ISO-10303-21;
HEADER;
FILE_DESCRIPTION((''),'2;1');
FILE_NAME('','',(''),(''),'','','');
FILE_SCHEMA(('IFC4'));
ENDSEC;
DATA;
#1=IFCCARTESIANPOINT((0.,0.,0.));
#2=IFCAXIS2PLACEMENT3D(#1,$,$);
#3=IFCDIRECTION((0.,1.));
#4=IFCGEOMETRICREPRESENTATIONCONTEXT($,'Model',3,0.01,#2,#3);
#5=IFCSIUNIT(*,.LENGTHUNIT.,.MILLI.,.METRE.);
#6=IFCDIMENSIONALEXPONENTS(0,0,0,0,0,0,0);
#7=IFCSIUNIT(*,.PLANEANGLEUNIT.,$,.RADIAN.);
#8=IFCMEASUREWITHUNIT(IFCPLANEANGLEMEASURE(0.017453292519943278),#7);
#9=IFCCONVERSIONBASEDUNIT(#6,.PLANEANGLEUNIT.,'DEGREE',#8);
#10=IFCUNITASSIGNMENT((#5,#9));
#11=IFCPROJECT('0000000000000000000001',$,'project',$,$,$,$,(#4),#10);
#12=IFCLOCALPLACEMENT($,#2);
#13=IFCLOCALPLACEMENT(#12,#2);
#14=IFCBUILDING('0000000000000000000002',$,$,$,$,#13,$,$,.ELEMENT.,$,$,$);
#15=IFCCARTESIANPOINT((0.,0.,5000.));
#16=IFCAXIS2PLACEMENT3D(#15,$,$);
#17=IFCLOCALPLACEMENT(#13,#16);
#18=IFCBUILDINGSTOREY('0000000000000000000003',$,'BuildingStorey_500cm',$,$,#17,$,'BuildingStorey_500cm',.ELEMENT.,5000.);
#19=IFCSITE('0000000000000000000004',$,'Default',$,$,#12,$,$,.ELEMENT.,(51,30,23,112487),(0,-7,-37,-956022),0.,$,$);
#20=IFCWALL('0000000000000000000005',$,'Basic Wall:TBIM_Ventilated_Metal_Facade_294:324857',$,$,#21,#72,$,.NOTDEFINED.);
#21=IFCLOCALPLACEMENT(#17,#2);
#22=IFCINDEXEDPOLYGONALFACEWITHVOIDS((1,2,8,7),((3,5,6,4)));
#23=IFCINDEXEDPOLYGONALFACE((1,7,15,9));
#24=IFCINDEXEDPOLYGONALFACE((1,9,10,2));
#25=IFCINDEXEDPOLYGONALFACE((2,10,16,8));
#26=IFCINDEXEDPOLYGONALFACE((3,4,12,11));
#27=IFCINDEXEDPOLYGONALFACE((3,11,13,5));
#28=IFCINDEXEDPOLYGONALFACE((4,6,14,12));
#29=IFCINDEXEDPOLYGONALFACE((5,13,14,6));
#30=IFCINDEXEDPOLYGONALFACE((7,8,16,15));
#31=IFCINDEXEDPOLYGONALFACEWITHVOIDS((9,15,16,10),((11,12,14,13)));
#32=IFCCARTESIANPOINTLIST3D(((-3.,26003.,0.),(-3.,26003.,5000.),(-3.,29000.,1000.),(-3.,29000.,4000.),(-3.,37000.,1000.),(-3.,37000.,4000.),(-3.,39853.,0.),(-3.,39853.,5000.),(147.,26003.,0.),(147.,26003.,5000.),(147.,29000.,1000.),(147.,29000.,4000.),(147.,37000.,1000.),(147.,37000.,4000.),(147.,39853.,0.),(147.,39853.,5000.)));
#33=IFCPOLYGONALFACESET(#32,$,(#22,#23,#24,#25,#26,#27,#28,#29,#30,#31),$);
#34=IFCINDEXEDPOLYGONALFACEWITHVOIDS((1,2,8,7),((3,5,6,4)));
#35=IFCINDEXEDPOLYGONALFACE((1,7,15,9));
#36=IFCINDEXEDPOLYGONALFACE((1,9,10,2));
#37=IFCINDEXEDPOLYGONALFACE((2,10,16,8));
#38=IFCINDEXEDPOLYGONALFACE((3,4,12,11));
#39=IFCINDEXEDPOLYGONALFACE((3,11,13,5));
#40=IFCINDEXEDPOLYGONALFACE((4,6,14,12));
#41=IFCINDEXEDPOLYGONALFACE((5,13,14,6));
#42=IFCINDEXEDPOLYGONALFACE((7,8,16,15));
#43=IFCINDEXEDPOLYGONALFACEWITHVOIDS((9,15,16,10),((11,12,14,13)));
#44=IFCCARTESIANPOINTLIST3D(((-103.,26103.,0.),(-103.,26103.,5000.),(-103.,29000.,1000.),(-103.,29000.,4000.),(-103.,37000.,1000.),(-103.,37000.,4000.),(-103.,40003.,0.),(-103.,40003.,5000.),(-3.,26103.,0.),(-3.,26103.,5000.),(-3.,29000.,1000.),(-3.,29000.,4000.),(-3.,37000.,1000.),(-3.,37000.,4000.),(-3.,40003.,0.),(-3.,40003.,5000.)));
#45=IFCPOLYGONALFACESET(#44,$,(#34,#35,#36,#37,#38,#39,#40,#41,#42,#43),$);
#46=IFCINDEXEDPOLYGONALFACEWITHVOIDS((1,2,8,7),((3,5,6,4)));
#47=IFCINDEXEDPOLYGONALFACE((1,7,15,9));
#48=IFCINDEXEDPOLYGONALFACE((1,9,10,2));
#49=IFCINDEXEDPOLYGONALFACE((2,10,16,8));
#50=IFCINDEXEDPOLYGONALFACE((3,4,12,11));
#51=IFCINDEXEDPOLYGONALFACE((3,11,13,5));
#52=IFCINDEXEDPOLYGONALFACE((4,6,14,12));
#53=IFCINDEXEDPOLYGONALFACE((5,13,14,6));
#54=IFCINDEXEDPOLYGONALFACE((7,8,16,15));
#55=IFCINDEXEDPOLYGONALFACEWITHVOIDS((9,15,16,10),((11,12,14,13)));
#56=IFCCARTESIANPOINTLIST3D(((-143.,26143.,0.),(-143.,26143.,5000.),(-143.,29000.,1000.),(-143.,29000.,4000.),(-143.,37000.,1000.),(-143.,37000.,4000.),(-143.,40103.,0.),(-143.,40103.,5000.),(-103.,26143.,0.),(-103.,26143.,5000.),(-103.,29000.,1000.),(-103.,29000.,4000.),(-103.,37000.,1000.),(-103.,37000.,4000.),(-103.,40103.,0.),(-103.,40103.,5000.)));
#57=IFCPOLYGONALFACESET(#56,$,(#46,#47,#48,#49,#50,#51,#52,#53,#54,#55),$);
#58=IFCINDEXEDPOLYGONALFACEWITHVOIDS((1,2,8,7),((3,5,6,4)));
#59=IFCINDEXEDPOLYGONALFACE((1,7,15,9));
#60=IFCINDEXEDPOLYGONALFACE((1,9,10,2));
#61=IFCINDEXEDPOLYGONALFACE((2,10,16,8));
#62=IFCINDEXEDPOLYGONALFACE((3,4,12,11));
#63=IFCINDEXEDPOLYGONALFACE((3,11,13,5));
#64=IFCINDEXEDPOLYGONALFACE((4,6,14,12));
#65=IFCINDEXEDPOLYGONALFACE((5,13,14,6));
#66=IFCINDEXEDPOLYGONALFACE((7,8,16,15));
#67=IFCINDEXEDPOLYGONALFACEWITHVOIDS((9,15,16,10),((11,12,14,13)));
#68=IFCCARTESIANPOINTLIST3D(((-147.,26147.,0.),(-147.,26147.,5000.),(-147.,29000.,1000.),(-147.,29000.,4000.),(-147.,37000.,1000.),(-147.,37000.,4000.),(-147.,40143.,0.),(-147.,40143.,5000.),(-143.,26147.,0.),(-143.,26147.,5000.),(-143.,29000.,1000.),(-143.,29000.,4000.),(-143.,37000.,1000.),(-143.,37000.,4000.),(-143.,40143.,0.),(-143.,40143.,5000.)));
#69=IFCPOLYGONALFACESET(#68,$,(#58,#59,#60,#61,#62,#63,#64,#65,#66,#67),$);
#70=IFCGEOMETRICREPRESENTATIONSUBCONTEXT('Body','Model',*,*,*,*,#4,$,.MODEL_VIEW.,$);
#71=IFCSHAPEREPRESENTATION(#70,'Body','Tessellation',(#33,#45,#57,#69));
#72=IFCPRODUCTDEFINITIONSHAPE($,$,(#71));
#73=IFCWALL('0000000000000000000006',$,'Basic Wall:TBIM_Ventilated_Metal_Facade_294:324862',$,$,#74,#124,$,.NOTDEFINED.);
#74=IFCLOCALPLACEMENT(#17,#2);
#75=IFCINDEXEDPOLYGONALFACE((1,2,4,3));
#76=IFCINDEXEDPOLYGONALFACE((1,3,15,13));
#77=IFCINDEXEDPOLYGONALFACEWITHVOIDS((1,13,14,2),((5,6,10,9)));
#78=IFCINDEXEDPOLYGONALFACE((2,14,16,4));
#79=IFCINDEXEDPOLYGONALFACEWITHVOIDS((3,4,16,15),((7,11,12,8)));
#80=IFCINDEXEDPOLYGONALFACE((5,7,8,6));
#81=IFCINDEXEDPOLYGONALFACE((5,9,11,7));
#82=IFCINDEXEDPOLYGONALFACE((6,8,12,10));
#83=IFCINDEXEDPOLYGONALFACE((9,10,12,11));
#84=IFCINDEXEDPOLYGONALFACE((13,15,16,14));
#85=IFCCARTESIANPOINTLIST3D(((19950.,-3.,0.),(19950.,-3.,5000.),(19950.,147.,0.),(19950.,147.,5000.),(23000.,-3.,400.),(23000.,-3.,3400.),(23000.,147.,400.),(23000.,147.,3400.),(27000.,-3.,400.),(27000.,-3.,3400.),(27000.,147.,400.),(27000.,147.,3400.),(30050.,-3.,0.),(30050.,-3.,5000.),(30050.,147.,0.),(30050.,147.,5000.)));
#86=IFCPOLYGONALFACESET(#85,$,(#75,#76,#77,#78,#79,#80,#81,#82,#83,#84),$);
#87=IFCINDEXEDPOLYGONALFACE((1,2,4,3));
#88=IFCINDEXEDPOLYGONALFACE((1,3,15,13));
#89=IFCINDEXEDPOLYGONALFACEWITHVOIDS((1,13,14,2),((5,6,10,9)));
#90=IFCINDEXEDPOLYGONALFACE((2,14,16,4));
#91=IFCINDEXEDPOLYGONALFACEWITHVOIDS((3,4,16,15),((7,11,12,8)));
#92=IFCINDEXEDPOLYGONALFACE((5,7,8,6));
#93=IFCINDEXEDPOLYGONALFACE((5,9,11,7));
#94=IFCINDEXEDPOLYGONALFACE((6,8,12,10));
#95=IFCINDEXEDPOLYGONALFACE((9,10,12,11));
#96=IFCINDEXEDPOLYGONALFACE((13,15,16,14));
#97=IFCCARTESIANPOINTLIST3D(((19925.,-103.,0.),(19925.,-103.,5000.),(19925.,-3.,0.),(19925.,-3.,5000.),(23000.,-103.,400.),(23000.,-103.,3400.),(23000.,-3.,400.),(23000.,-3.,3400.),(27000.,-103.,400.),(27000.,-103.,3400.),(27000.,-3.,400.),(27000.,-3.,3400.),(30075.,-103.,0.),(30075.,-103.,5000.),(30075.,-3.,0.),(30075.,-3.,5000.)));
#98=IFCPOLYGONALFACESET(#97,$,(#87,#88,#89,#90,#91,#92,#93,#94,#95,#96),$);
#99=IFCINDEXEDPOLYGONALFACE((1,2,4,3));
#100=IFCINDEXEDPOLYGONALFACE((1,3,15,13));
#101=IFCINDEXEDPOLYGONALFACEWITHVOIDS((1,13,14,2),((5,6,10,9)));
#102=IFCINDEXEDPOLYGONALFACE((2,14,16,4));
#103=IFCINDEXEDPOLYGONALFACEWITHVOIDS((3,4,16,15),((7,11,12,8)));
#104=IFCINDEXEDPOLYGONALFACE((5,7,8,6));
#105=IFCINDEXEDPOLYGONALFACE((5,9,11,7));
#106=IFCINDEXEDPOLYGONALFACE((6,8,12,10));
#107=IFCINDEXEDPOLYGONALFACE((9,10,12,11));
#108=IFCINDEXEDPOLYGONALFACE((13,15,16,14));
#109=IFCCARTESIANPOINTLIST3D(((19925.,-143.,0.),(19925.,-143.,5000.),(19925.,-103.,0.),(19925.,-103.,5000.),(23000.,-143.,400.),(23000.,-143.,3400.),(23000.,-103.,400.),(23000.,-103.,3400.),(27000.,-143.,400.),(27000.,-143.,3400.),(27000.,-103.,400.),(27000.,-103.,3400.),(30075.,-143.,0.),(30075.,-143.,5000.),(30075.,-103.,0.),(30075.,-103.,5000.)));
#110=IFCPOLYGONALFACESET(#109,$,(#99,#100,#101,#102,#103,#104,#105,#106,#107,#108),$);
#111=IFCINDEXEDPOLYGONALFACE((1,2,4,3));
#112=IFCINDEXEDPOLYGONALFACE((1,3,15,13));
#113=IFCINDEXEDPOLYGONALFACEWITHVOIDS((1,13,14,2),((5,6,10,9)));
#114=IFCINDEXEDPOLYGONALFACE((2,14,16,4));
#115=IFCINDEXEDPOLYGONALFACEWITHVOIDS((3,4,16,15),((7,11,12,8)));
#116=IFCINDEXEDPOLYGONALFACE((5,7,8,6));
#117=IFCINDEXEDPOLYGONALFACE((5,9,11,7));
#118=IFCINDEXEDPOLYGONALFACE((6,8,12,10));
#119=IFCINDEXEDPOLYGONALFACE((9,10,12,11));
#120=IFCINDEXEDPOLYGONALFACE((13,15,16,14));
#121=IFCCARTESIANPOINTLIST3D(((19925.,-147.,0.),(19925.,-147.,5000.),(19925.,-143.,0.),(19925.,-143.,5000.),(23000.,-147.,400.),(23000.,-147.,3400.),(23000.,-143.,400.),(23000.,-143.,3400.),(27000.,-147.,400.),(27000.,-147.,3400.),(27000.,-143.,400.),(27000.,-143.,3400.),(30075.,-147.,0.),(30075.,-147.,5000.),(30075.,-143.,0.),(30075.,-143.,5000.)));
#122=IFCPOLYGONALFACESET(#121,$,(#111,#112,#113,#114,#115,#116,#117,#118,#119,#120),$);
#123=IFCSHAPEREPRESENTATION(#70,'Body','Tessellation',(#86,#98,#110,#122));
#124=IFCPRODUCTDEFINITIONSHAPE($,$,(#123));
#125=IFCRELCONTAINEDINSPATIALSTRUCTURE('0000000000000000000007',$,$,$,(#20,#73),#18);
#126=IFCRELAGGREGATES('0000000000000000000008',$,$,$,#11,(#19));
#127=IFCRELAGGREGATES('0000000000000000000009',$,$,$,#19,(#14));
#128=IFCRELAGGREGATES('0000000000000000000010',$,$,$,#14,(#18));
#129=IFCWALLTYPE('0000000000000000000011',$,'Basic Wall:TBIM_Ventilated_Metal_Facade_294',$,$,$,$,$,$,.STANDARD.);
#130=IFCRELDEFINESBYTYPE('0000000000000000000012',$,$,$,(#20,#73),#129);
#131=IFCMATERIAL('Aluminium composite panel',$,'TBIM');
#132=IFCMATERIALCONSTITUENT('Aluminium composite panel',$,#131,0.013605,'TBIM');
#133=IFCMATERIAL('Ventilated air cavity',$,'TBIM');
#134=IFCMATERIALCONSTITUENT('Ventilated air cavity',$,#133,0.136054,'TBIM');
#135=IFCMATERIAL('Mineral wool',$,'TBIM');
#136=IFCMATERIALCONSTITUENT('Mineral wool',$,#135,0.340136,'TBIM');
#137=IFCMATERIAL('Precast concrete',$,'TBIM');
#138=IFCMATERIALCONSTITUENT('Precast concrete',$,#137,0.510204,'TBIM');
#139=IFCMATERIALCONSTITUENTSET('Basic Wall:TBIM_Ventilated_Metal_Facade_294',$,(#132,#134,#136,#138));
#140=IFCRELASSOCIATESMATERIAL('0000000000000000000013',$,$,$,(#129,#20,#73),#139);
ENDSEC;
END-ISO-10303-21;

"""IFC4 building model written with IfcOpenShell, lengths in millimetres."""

from ifc_helpers import new_model, entity, si_unit, converted_unit, direction, frame, origin, place, context, subcontext, project, spatial, indexed_curve, outline, extrude, material, constituent, constituent_set, type_object, element, save


model = new_model("IFC4")

# Units and contexts
model_context = context("Model", 3, precision=0.01, world=origin(), true_north=direction((0.0, 1.0)))
body_context = subcontext(model_context, "Body", "Model", "MODEL_VIEW")
ifc_project = project(units=[si_unit("LENGTHUNIT", "METRE", prefix="MILLI"), converted_unit("PLANEANGLEUNIT", "DEGREE", entity("IfcPlaneAngleMeasure", 0.017453292519943278), si_unit("PLANEANGLEUNIT", "RADIAN"), dimensions=[0, 0, 0, 0, 0, 0, 0])], contexts=[model_context])

# Site, building, storey
site_placement = place(None, origin())
site = spatial("IfcSite", under=ifc_project, at=site_placement, Name="Default", CompositionType="ELEMENT", RefLatitude=(51, 30, 23, 112487), RefLongitude=(0, -7, -37, -956022), RefElevation=0.0)
building_placement = place(site_placement, origin())
building = spatial("IfcBuilding", under=site, at=building_placement, CompositionType="ELEMENT")
storey_placement = place(building_placement, frame((0.0, 0.0, 5000.0)))
storey = spatial("IfcBuildingStorey", under=building, at=storey_placement, Name="BuildingStorey_500cm", LongName="BuildingStorey_500cm", CompositionType="ELEMENT", Elevation=5000.0)

# Shared definitions
ifc_material_1 = material(Name="Aluminium composite panel", Category="TBIM")
ifc_constituent_1 = constituent(ifc_material_1, Name="Aluminium composite panel", Category="TBIM", fraction=0.013605)
ifc_material_2 = material(Name="Ventilated air cavity", Category="TBIM")
ifc_constituent_2 = constituent(ifc_material_2, Name="Ventilated air cavity", Category="TBIM", fraction=0.136054)
ifc_material_3 = material(Name="Mineral wool", Category="TBIM")
ifc_constituent_3 = constituent(ifc_material_3, Name="Mineral wool", Category="TBIM", fraction=0.340136)
ifc_material_4 = material(Name="Precast concrete", Category="TBIM")
ifc_constituent_4 = constituent(ifc_material_4, Name="Precast concrete", Category="TBIM", fraction=0.510204)
ifc_constituent_set_1 = constituent_set(constituents=[ifc_constituent_1, ifc_constituent_2, ifc_constituent_3, ifc_constituent_4], Name="Basic Wall:TBIM_Ventilated_Metal_Facade_294")
wall_type_1 = type_object("IfcWallType", Name="Basic Wall:TBIM_Ventilated_Metal_Facade_294", PredefinedType="STANDARD", material=ifc_constituent_set_1)

# Walls, openings
wall_1_placement = place(storey_placement, frame((0.0, 26147.0, 0.0), z_axis=(0.0, 0.0, 1.0), x_axis=(0.0, 1.0, 0.0)))
wall_1 = element("IfcWall", 1, at=wall_1_placement, inside=storey, type_object=wall_type_1, material=ifc_constituent_set_1, Name="Basic Wall:TBIM_Ventilated_Metal_Facade_294:324857", PredefinedType="NOTDEFINED", context=body_context, shape_type="SweptSolid", body=[
    extrude(outline(indexed_curve([(-2500.0, -6925.0), (2500.0, -6925.0), (2500.0, 6925.0), (-2500.0, 6925.0), (-2500.0, -6925.0)], self_intersect=False), holes=[indexed_curve([(1500.0, 3928.0), (1500.0, -4072.0), (-1500.0, -4072.0), (-1500.0, 3928.0), (1500.0, 3928.0)], self_intersect=False)]), frame((6781.0, 3.0, 2500.0), z_axis=(0.0, -1.0, 0.0), x_axis=(0.0, 0.0, 1.0)), (0.0, 0.0, 1.0), 150.0),
    extrude(outline(indexed_curve([(-2500.0, -6950.0), (2500.0, -6950.0), (2500.0, 6950.0), (-2500.0, 6950.0), (-2500.0, -6950.0)], self_intersect=False), holes=[indexed_curve([(1500.0, 4053.0), (1500.0, -3947.0), (-1500.0, -3947.0), (-1500.0, 4053.0), (1500.0, 4053.0)], self_intersect=False)]), frame((6906.0, 103.0, 2500.0), z_axis=(0.0, -1.0, 0.0), x_axis=(0.0, 0.0, 1.0)), (0.0, 0.0, 1.0), 100.0),
    extrude(outline(indexed_curve([(-2500.0, -6980.0), (2500.0, -6980.0), (2500.0, 6980.0), (-2500.0, 6980.0), (-2500.0, -6980.0)], self_intersect=False), holes=[indexed_curve([(1500.0, 4123.0), (1500.0, -3877.0), (-1500.0, -3877.0), (-1500.0, 4123.0), (1500.0, 4123.0)], self_intersect=False)]), frame((6976.0, 143.0, 2500.0), z_axis=(0.0, -1.0, 0.0), x_axis=(0.0, 0.0, 1.0)), (0.0, 0.0, 1.0), 40.0),
    extrude(outline(indexed_curve([(-6998.0, -2500.0), (6998.0, -2500.0), (6998.0, 2500.0), (-6998.0, 2500.0), (-6998.0, -2500.0)], self_intersect=False), holes=[indexed_curve([(-4145.0, 1500.0), (3855.0, 1500.0), (3855.0, -1500.0), (-4145.0, -1500.0), (-4145.0, 1500.0)], self_intersect=False)]), frame((6998.0, 147.0, 2500.0), z_axis=(0.0, -1.0, 0.0), x_axis=(1.0, 0.0, 0.0)), (0.0, 0.0, 1.0), 4.0),
])
opening_1_placement = place(wall_1_placement, frame((2853.0, -147.0, 1000.0)))
element("IfcOpeningElement", 2, at=opening_1_placement, cuts=wall_1, PredefinedType="OPENING", context=body_context, shape_type="SweptSolid", body=[
    extrude(outline(indexed_curve([(3000.0, 0.0), (3000.0, 8000.0), (0.0, 8000.0), (0.0, 0.0), (3000.0, 0.0)], self_intersect=False)), frame((0.0, 0.0, 0.0), z_axis=(0.0, 1.0, 0.0), x_axis=(0.0, 0.0, 1.0)), (0.0, 0.0, 1.0), 294.0),
])
wall_2_placement = place(storey_placement, frame((19925.0, 0.0, 0.0)))
wall_2 = element("IfcWall", 3, at=wall_2_placement, inside=storey, type_object=wall_type_1, material=ifc_constituent_set_1, Name="Basic Wall:TBIM_Ventilated_Metal_Facade_294:324862", PredefinedType="NOTDEFINED", context=body_context, shape_type="SweptSolid", body=[
    extrude(outline(indexed_curve([(-2500.0, -5050.0), (2500.0, -5050.0), (2500.0, 5050.0), (-2500.0, 5050.0), (-2500.0, -5050.0)], self_intersect=False), holes=[indexed_curve([(-2100.0, -2000.0), (-2100.0, 2000.0), (900.0, 2000.0), (900.0, -2000.0), (-2100.0, -2000.0)], self_intersect=False)]), frame((5075.0, -3.0, 2500.0), z_axis=(0.0, 1.0, 0.0), x_axis=(0.0, 0.0, 1.0)), (0.0, 0.0, 1.0), 150.0),
    extrude(outline(indexed_curve([(-2500.0, -5075.0), (2500.0, -5075.0), (2500.0, 5075.0), (-2500.0, 5075.0), (-2500.0, -5075.0)], self_intersect=False), holes=[indexed_curve([(-2100.0, -2000.0), (-2100.0, 2000.0), (900.0, 2000.0), (900.0, -2000.0), (-2100.0, -2000.0)], self_intersect=False)]), frame((5075.0, -103.0, 2500.0), z_axis=(0.0, 1.0, 0.0), x_axis=(0.0, 0.0, 1.0)), (0.0, 0.0, 1.0), 100.0),
    extrude(outline(indexed_curve([(-2500.0, -5075.0), (2500.0, -5075.0), (2500.0, 5075.0), (-2500.0, 5075.0), (-2500.0, -5075.0)], self_intersect=False), holes=[indexed_curve([(-2100.0, -2000.0), (-2100.0, 2000.0), (900.0, 2000.0), (900.0, -2000.0), (-2100.0, -2000.0)], self_intersect=False)]), frame((5075.0, -143.0, 2500.0), z_axis=(0.0, 1.0, 0.0), x_axis=(0.0, 0.0, 1.0)), (0.0, 0.0, 1.0), 40.0),
    extrude(outline(indexed_curve([(-2500.0, -5075.0), (2500.0, -5075.0), (2500.0, 5075.0), (-2500.0, 5075.0), (-2500.0, -5075.0)], self_intersect=False), holes=[indexed_curve([(900.0, -2000.0), (-2100.0, -2000.0), (-2100.0, 2000.0), (900.0, 2000.0), (900.0, -2000.0)], self_intersect=False)]), frame((5075.0, -147.0, 2500.0), z_axis=(0.0, 1.0, 0.0), x_axis=(0.0, 0.0, 1.0)), (0.0, 0.0, 1.0), 4.0),
])
opening_2_placement = place(wall_2_placement, frame((3075.0, -147.0, 400.0)))
element("IfcOpeningElement", 4, at=opening_2_placement, cuts=wall_2, PredefinedType="OPENING", context=body_context, shape_type="SweptSolid", body=[
    extrude(outline(indexed_curve([(3000.0, 0.0), (3000.0, 4000.0), (0.0, 4000.0), (0.0, 0.0), (3000.0, 0.0)], self_intersect=False)), frame((0.0, 0.0, 0.0), z_axis=(0.0, 1.0, 0.0), x_axis=(0.0, 0.0, 1.0)), (0.0, 0.0, 1.0), 294.0),
])

save(model, "model.ifc")
